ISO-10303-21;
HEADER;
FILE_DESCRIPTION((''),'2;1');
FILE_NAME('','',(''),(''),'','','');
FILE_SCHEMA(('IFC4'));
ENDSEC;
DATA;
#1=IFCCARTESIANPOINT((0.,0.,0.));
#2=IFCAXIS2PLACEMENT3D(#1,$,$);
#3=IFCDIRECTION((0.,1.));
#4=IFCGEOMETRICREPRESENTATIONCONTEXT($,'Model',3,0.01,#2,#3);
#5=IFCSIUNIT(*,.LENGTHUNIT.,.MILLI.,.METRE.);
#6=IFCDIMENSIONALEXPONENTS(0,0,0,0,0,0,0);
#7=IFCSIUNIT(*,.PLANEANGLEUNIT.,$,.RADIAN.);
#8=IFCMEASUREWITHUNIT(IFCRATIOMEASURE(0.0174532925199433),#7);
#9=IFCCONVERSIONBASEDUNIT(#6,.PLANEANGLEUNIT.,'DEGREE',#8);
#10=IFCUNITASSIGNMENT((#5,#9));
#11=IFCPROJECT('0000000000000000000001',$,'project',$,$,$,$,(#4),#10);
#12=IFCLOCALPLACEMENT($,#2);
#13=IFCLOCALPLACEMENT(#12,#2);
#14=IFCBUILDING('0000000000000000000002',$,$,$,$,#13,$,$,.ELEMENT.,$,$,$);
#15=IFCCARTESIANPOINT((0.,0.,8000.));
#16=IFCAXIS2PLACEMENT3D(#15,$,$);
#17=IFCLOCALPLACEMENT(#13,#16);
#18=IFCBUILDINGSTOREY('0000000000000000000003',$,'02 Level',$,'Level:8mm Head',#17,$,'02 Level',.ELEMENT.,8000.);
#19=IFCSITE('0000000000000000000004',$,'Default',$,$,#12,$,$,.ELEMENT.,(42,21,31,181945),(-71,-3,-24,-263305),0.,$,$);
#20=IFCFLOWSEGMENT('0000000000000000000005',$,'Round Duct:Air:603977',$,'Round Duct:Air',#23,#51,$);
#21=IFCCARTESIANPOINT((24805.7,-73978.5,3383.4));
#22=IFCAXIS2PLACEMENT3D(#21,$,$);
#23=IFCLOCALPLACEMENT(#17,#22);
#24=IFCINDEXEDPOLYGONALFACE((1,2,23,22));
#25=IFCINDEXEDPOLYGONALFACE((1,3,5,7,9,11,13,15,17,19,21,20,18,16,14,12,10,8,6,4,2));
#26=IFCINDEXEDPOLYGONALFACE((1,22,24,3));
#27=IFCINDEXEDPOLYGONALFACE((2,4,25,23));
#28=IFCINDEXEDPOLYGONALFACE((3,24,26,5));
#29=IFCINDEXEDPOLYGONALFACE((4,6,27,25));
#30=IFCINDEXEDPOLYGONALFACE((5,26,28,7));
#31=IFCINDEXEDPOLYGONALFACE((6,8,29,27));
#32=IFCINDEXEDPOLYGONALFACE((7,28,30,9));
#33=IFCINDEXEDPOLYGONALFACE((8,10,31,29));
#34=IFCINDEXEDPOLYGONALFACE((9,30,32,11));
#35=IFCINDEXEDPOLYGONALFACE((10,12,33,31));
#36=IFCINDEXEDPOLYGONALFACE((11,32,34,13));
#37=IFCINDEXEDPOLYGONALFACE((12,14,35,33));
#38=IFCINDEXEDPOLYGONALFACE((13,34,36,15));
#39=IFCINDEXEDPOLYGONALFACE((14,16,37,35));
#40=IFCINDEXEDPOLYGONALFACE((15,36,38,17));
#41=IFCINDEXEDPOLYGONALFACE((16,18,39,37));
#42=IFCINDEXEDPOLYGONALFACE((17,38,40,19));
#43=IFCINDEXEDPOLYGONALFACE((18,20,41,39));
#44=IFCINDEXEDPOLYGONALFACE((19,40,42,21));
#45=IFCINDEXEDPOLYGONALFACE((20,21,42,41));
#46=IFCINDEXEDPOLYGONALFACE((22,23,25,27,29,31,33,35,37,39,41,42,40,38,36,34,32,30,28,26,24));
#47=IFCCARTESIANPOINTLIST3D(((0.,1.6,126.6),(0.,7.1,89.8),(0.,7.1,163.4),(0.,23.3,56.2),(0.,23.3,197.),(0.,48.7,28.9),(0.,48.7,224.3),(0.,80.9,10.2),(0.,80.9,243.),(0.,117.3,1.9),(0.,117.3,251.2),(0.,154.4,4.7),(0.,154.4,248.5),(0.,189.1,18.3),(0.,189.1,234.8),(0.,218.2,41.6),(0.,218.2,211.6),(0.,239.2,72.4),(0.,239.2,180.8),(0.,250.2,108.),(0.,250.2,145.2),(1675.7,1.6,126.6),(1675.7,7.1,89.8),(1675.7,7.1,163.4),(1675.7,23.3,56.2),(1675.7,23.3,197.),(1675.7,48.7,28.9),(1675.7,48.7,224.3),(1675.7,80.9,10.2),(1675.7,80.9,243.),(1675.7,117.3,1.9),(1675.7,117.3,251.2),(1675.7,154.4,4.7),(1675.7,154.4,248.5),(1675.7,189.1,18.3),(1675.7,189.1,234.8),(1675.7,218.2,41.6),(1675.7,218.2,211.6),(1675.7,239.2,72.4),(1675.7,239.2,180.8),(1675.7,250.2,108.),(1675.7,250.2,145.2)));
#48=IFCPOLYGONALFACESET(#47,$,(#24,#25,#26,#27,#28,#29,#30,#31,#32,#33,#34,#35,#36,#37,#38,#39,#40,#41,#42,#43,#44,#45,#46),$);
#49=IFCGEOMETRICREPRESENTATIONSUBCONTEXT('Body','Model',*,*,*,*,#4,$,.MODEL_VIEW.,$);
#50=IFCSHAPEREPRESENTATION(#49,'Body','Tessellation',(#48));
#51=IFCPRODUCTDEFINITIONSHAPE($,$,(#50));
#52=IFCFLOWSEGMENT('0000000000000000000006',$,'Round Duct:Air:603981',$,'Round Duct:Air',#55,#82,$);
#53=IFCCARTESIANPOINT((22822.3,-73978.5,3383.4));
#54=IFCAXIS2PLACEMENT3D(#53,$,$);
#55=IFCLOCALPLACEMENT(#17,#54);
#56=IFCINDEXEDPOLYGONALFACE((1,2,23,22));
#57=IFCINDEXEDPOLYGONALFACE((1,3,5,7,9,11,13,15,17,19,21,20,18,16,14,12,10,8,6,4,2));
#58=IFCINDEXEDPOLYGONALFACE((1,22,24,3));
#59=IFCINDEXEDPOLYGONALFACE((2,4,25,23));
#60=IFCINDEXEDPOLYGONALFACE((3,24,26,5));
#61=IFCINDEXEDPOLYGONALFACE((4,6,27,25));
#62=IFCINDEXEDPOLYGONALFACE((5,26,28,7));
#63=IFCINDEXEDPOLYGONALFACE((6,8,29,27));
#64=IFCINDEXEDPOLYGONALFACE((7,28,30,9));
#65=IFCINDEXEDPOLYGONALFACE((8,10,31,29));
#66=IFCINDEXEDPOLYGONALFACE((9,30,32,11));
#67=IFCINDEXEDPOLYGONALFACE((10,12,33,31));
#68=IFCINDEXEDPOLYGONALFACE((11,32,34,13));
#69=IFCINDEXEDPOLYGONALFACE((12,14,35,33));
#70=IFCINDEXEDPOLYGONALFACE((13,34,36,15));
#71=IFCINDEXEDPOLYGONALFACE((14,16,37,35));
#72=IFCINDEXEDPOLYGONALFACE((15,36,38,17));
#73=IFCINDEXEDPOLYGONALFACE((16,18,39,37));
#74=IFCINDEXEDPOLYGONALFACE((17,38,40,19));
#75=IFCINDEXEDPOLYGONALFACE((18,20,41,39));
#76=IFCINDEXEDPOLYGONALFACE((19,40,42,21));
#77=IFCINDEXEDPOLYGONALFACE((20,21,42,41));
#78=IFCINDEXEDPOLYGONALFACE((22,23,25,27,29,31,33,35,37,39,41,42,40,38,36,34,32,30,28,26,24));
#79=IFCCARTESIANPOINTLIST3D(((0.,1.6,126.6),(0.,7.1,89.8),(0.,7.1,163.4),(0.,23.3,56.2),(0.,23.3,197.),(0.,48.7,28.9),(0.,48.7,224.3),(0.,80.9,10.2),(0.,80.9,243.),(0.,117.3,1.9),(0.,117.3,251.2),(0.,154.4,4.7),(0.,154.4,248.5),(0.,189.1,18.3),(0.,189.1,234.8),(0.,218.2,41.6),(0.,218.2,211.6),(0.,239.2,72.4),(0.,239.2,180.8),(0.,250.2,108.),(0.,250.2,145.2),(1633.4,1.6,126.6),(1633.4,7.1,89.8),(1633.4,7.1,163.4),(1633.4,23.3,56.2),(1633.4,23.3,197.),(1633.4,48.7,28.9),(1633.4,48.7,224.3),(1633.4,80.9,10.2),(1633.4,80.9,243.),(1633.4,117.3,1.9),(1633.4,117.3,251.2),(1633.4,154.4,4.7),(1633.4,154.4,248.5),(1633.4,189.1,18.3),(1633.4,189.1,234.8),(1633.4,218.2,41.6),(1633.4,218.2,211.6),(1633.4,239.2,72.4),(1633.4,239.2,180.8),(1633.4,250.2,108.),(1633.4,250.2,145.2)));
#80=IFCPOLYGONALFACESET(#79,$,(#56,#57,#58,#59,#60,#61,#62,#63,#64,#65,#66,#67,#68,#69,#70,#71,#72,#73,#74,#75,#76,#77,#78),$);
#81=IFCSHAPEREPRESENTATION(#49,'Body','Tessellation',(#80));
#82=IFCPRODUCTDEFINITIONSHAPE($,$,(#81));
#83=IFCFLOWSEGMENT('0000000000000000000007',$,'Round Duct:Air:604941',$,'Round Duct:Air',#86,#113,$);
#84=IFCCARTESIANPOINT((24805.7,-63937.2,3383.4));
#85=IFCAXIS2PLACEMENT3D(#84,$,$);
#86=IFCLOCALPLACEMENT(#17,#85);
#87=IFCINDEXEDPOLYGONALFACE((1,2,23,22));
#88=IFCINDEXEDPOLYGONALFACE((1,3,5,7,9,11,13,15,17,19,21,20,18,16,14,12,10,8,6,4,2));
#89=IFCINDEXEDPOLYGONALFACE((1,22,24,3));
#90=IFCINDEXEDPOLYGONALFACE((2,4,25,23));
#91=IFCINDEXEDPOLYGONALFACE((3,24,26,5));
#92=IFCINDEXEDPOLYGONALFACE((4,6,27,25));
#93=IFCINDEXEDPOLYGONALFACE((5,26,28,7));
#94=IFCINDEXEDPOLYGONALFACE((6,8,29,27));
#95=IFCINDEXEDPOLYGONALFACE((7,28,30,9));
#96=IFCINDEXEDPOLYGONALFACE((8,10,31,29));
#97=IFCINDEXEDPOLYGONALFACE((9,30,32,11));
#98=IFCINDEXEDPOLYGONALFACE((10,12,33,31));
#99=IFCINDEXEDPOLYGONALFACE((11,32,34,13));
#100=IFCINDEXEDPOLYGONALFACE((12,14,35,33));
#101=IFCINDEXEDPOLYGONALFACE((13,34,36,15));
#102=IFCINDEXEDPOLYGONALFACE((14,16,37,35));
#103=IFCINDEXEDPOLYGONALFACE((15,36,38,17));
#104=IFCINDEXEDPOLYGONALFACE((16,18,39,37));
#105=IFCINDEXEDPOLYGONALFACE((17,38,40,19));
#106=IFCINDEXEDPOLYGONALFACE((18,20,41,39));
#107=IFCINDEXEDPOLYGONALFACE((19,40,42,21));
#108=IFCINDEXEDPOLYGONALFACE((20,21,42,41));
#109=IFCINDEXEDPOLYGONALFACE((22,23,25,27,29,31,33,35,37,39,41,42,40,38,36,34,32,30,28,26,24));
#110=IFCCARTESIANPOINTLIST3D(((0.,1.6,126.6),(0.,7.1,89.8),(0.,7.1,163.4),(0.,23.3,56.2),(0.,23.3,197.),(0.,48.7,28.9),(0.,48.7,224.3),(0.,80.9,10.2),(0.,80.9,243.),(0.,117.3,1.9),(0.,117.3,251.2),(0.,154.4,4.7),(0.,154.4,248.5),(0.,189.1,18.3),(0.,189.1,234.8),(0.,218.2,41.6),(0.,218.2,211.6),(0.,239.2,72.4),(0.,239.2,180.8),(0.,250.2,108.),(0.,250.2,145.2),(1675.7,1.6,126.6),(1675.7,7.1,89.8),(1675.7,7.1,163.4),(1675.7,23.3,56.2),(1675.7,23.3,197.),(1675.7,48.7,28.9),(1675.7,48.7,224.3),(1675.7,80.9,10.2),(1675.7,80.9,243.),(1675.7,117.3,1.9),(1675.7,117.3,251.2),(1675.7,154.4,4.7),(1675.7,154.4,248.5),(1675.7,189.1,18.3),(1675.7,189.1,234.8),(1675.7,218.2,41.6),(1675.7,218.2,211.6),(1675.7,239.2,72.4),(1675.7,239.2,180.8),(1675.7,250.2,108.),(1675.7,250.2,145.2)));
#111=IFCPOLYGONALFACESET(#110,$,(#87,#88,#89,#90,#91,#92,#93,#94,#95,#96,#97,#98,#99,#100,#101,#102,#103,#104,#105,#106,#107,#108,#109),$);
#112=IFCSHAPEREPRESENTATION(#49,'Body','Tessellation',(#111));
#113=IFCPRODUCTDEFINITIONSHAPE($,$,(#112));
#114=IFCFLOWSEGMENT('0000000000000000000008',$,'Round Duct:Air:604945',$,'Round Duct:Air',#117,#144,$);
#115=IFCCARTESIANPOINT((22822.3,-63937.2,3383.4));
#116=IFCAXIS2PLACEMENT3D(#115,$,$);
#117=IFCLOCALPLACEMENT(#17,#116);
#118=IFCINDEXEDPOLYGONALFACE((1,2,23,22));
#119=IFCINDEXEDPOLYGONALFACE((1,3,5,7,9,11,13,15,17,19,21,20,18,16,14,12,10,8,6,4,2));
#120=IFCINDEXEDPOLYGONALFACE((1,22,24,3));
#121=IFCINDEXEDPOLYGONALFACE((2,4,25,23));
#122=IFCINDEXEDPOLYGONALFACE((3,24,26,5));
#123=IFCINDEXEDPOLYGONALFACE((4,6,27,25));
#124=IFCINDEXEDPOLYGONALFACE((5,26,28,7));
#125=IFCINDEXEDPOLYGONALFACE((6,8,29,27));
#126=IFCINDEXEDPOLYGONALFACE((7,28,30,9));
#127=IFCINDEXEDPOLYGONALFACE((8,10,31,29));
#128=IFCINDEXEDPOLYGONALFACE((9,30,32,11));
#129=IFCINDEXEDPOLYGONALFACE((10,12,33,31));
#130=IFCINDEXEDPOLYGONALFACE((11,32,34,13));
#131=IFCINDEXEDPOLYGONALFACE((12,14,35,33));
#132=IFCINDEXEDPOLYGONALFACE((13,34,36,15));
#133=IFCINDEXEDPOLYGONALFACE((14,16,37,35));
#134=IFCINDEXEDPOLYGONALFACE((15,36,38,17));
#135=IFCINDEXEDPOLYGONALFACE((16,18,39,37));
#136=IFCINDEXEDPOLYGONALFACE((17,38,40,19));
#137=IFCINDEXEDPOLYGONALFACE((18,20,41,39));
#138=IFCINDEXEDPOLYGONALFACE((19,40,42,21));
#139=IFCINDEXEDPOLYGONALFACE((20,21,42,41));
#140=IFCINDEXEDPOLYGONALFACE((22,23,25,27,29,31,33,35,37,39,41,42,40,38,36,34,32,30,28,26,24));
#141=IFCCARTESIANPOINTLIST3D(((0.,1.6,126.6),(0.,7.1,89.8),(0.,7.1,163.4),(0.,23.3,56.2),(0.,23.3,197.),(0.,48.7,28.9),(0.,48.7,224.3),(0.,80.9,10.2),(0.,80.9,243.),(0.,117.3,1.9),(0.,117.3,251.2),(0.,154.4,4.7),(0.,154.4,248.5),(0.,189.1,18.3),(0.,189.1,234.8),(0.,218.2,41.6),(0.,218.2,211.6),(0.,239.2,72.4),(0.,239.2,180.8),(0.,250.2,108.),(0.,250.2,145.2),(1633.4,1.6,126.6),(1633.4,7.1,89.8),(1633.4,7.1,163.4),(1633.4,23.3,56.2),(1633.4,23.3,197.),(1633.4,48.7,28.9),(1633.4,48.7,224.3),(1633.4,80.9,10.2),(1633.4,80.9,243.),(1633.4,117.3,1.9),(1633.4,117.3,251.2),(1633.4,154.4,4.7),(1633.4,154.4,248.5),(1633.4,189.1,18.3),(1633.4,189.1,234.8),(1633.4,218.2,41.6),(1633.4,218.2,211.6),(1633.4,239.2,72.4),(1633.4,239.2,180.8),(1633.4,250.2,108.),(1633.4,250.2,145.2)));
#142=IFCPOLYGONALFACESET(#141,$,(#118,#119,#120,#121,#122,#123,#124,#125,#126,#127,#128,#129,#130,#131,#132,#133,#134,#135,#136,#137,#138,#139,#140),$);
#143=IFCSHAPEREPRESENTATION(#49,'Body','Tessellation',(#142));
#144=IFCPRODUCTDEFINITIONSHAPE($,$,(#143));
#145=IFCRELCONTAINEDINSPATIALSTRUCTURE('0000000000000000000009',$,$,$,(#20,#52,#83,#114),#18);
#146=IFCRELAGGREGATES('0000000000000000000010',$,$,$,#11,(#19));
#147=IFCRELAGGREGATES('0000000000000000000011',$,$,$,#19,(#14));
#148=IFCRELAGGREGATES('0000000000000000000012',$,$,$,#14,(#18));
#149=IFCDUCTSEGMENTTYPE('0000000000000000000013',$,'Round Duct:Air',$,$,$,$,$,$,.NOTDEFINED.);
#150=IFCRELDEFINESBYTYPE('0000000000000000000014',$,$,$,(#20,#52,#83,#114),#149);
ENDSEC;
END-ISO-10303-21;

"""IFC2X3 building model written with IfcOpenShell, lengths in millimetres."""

from ifc_helpers import new_model, entity, si_unit, converted_unit, direction, frame, origin, origin_2d_with_axis, place, context, subcontext, project, spatial, circle, extrude, type_object, element, save


model = new_model("IFC2X3")

# Units and contexts
model_context = context("Model", 3, precision=0.01, world=origin(), true_north=direction((0.0, 1.0)))
body_context = subcontext(model_context, "Body", "Model", "MODEL_VIEW")
ifc_project = project(units=[si_unit("LENGTHUNIT", "METRE", prefix="MILLI"), converted_unit("PLANEANGLEUNIT", "DEGREE", entity("IfcRatioMeasure", 0.0174532925199433), si_unit("PLANEANGLEUNIT", "RADIAN"), dimensions=[0, 0, 0, 0, 0, 0, 0])], contexts=[model_context])

# Site, building, storey
site_placement = place(None, origin())
site = spatial("IfcSite", under=ifc_project, at=site_placement, Name="Default", CompositionType="ELEMENT", RefLatitude=(42, 21, 31, 181945), RefLongitude=(-71, -3, -24, -263305), RefElevation=0.0)
building_placement = place(site_placement, origin())
building = spatial("IfcBuilding", under=site, at=building_placement, CompositionType="ELEMENT")
storey_placement = place(building_placement, frame((0.0, 0.0, 8000.0)))
storey = spatial("IfcBuildingStorey", under=building, at=storey_placement, Name="02 Level", ObjectType="Level:8mm Head", LongName="02 Level", CompositionType="ELEMENT", Elevation=8000.0)

# Flow segments
duct_segment_type_1 = type_object("IfcDuctSegmentType", Name="Round Duct:Air", PredefinedType="NOTDEFINED")
flow_segment_1_placement = place(storey_placement, frame((24805.7, -73978.5, 3383.4)))
element("IfcFlowSegment", 1, at=flow_segment_1_placement, inside=storey, type_object=duct_segment_type_1, Name="Round Duct:Air:603977", ObjectType="Round Duct:Air", context=body_context, shape_type="SweptSolid", body=[
    extrude(circle(Radius=125.0, at=origin_2d_with_axis()), frame((0.0, 126.6, 126.6), z_axis=(1.0, 0.0, 0.0), x_axis=(0.0, -1.0, 0.0)), (0.0, 0.0, 1.0), 1675.7),
])
flow_segment_2_placement = place(storey_placement, frame((22822.3, -73978.5, 3383.4)))
element("IfcFlowSegment", 2, at=flow_segment_2_placement, inside=storey, type_object=duct_segment_type_1, Name="Round Duct:Air:603981", ObjectType="Round Duct:Air", context=body_context, shape_type="SweptSolid", body=[
    extrude(circle(Radius=125.0, at=origin_2d_with_axis()), frame((0.0, 126.6, 126.6), z_axis=(1.0, 0.0, 0.0), x_axis=(0.0, -1.0, 0.0)), (0.0, 0.0, 1.0), 1633.4),
])
flow_segment_3_placement = place(storey_placement, frame((24805.7, -63937.2, 3383.4)))
element("IfcFlowSegment", 3, at=flow_segment_3_placement, inside=storey, type_object=duct_segment_type_1, Name="Round Duct:Air:604941", ObjectType="Round Duct:Air", context=body_context, shape_type="SweptSolid", body=[
    extrude(circle(Radius=125.0, at=origin_2d_with_axis()), frame((0.0, 126.6, 126.6), z_axis=(1.0, 0.0, 0.0), x_axis=(0.0, -1.0, 0.0)), (0.0, 0.0, 1.0), 1675.7),
])
flow_segment_4_placement = place(storey_placement, frame((22822.3, -63937.2, 3383.4)))
element("IfcFlowSegment", 4, at=flow_segment_4_placement, inside=storey, type_object=duct_segment_type_1, Name="Round Duct:Air:604945", ObjectType="Round Duct:Air", context=body_context, shape_type="SweptSolid", body=[
    extrude(circle(Radius=125.0, at=origin_2d_with_axis()), frame((0.0, 126.6, 126.6), z_axis=(1.0, 0.0, 0.0), x_axis=(0.0, -1.0, 0.0)), (0.0, 0.0, 1.0), 1633.4),
])

save(model, "model.ifc")
